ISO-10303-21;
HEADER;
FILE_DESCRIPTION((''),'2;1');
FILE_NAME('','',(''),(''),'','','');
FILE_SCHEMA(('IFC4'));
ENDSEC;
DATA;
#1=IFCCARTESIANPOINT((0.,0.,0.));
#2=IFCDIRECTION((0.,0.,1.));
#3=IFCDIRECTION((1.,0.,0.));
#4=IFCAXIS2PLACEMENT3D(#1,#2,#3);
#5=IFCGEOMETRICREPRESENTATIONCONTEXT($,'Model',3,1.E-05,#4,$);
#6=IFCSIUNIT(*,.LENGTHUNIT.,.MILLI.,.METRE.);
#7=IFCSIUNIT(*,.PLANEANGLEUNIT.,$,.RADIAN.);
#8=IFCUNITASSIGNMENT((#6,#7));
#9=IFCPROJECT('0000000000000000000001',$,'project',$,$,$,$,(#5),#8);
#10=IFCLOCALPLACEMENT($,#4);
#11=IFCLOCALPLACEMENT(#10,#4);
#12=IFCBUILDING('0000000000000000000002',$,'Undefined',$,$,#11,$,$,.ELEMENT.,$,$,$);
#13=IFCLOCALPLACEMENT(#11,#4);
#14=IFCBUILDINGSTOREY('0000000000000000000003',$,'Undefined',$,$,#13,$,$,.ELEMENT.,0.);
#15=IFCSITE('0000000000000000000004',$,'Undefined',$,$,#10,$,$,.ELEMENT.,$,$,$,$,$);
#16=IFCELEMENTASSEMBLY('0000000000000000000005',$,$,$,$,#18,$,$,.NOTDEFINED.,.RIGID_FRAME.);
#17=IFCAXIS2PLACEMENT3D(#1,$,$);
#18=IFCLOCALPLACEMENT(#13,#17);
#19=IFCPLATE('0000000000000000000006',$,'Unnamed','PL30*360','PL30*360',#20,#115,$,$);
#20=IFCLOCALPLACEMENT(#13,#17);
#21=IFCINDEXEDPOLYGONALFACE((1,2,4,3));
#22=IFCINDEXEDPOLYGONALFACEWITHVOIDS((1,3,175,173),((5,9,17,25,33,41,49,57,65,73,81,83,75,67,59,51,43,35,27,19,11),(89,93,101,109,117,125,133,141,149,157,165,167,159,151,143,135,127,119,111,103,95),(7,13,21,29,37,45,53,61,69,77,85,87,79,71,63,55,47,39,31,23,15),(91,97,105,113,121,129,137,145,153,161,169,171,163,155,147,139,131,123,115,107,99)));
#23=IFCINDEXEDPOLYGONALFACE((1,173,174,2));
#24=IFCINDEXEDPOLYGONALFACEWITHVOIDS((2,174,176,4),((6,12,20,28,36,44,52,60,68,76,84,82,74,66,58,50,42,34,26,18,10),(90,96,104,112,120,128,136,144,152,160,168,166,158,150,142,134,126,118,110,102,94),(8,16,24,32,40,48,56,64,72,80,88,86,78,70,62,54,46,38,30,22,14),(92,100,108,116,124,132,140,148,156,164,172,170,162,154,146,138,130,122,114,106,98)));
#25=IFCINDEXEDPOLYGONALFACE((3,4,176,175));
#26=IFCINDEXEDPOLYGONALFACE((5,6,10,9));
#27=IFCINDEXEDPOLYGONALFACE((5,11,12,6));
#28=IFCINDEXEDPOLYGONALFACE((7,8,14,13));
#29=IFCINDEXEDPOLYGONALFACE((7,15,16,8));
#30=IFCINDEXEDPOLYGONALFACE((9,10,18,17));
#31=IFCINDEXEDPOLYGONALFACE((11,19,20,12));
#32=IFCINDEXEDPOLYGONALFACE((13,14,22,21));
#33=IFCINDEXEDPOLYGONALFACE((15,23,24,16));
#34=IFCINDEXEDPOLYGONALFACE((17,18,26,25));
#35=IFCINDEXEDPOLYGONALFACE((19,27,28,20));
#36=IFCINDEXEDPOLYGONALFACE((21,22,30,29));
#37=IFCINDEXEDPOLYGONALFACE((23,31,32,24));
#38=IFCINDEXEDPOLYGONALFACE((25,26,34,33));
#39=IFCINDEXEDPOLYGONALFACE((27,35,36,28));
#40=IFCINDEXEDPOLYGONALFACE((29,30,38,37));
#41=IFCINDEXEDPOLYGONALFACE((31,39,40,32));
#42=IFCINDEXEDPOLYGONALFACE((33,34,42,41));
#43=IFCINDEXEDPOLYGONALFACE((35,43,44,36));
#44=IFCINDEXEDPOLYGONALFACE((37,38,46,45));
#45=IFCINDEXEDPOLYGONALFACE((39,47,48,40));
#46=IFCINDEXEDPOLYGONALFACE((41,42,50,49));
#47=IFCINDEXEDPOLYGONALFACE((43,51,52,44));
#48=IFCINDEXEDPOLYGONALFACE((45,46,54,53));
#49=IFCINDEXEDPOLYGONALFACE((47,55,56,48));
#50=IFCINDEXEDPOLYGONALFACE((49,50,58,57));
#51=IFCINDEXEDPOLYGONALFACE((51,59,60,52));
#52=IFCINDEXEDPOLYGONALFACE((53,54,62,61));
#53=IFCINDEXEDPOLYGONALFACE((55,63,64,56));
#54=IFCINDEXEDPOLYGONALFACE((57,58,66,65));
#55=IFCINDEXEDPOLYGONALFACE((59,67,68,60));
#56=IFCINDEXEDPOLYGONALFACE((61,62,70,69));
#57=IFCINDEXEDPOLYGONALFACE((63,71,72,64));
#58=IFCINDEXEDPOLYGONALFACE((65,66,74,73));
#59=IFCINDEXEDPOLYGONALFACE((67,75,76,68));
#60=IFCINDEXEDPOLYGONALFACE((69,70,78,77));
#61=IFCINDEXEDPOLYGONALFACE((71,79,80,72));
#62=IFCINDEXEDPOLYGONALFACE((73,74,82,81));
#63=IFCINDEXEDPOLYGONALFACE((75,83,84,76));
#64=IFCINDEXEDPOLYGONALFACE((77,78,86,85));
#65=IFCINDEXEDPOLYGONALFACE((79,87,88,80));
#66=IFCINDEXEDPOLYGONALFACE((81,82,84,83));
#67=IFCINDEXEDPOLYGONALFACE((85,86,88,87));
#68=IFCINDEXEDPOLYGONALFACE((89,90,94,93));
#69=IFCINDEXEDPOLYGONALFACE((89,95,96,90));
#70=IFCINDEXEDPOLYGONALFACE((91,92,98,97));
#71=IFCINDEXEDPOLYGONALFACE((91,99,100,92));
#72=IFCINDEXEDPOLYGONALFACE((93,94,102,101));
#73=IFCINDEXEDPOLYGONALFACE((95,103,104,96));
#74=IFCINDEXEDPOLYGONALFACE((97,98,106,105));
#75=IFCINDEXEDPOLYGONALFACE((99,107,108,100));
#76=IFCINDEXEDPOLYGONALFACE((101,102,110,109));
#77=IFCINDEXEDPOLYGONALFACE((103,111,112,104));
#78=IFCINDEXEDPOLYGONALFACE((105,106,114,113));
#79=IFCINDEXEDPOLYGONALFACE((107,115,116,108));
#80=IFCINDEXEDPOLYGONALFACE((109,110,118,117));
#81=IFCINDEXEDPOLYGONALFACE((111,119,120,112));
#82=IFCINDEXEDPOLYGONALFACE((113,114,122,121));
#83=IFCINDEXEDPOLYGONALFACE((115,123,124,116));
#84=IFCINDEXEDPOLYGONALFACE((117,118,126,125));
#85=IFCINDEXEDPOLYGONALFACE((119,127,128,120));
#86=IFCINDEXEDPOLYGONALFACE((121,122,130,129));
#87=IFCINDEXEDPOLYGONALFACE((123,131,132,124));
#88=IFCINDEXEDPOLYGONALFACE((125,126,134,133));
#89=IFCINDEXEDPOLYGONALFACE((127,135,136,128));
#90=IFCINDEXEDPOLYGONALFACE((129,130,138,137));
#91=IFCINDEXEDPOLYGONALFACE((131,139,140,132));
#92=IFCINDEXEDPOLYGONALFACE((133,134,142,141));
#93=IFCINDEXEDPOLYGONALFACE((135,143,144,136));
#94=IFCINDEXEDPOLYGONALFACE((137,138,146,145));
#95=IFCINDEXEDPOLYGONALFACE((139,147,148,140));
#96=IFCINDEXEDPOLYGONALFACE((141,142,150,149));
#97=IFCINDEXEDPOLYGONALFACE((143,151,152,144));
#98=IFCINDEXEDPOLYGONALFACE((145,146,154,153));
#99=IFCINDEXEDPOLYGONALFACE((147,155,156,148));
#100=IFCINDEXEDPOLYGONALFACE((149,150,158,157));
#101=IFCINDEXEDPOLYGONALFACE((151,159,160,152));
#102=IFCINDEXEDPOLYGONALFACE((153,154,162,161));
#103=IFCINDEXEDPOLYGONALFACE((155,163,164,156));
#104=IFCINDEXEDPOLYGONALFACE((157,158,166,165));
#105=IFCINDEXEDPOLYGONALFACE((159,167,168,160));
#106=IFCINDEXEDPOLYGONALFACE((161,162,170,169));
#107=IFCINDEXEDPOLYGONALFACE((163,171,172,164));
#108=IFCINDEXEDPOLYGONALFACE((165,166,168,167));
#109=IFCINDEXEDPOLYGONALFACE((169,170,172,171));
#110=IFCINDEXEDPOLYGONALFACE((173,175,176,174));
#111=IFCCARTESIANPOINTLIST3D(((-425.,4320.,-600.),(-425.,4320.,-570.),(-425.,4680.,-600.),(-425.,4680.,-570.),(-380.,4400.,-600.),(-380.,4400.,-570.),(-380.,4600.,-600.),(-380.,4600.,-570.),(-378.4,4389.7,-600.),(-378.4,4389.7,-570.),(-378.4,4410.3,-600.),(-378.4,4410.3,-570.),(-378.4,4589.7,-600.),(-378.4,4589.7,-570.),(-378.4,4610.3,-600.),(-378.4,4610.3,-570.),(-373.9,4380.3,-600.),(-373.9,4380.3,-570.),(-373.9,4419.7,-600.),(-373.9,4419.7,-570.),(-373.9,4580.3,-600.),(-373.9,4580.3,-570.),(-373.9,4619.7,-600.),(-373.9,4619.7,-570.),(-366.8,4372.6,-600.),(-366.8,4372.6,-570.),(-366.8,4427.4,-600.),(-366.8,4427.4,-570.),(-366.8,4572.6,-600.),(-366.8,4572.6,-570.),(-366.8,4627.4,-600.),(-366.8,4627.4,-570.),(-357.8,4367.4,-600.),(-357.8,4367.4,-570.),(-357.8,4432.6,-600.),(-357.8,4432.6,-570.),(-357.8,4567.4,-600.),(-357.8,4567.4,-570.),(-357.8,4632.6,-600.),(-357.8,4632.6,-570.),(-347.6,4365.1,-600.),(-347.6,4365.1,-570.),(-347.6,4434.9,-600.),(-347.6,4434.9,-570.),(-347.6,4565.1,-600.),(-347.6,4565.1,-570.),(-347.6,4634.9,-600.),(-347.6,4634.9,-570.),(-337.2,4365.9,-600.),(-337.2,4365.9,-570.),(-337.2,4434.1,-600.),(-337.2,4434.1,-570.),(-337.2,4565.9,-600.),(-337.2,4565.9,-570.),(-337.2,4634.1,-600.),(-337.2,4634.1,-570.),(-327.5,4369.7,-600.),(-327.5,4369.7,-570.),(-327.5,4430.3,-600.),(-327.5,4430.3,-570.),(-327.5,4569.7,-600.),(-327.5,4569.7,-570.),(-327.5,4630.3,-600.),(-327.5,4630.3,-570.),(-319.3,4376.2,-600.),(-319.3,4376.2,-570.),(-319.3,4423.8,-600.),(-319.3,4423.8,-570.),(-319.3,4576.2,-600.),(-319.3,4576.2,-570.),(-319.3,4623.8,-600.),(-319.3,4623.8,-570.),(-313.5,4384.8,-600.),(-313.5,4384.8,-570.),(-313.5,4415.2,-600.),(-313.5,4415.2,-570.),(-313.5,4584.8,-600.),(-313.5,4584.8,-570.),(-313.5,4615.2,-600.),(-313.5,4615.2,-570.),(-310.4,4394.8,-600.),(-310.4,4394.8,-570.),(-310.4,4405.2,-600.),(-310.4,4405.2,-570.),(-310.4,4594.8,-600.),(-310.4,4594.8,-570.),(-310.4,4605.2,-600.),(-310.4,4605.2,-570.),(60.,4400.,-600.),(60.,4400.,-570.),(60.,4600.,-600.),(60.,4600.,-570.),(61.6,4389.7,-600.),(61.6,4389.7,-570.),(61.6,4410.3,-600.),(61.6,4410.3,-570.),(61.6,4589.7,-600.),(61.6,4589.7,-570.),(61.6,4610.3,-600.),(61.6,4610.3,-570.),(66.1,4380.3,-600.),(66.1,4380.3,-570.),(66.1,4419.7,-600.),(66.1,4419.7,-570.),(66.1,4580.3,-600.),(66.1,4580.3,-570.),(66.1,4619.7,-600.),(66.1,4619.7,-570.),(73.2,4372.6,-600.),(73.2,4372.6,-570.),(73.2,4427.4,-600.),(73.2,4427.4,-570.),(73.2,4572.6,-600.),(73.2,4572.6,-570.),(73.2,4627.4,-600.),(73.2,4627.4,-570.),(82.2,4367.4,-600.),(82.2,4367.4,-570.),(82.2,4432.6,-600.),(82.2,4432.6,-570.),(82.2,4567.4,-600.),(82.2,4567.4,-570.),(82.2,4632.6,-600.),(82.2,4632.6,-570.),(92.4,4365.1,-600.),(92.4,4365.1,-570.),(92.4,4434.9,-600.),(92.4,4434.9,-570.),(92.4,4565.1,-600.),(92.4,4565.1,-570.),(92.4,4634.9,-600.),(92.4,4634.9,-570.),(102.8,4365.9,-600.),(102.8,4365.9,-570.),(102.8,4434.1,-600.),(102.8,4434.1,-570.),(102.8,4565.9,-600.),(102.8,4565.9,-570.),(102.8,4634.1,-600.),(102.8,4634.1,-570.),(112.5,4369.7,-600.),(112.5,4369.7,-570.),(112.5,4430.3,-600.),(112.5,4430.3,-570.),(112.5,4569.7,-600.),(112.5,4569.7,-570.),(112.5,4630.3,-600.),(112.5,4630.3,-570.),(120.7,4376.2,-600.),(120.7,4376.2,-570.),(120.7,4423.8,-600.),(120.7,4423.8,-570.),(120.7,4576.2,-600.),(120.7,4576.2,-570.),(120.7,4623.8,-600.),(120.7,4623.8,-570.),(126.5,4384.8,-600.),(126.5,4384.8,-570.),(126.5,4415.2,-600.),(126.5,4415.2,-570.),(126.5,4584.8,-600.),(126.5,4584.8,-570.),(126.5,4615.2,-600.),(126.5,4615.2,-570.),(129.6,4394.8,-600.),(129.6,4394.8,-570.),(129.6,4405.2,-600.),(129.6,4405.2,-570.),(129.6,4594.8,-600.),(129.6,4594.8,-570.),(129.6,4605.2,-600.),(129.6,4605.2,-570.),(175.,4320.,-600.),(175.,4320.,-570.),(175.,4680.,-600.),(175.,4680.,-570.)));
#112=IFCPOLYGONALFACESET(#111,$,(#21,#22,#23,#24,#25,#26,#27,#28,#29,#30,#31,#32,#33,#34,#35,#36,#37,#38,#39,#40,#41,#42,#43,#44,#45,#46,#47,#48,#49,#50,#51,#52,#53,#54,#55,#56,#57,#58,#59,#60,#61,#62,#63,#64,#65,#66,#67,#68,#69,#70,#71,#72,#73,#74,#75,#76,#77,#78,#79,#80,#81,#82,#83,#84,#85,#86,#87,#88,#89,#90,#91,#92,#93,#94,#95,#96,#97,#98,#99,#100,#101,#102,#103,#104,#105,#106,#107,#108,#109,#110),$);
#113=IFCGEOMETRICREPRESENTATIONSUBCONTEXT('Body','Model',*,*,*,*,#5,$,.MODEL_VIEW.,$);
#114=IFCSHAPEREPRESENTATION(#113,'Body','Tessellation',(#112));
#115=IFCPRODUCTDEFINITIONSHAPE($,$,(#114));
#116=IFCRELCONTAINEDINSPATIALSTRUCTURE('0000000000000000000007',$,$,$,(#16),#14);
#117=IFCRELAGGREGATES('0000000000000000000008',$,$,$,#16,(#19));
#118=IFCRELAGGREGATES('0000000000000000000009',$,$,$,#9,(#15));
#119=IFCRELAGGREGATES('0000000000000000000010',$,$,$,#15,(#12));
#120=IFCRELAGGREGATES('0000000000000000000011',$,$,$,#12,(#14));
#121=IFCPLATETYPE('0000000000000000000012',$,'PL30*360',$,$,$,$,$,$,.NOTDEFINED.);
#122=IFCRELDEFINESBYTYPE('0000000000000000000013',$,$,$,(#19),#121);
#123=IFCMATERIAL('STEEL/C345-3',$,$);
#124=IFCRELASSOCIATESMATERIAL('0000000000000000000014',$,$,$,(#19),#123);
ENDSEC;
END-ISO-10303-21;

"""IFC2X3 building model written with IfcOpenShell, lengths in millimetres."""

from ifc_helpers import new_model, si_unit, frame, origin_with_axes, origin_2d_with_axis, place, context, subcontext, project, spatial, polyline, circle, outline, extrude, boolean, material, type_object, element, aggregate, save


model = new_model("IFC2X3")

# Units and contexts
model_context = context("Model", 3, precision=1e-05, world=origin_with_axes())
body_context = subcontext(model_context, "Body", "Model", "MODEL_VIEW")
ifc_project = project(units=[si_unit("LENGTHUNIT", "METRE", prefix="MILLI"), si_unit("PLANEANGLEUNIT", "RADIAN")], contexts=[model_context])

# Site, building, storey
site_placement = place(None, origin_with_axes())
site = spatial("IfcSite", under=ifc_project, at=site_placement, Name="Undefined", CompositionType="ELEMENT")
building_placement = place(site_placement, origin_with_axes())
building = spatial("IfcBuilding", under=site, at=building_placement, Name="Undefined", CompositionType="ELEMENT")
storey_placement = place(building_placement, origin_with_axes())
storey = spatial("IfcBuildingStorey", under=building, at=storey_placement, Name="Undefined", CompositionType="ELEMENT", Elevation=0.0)

# Shared definitions
ifc_material_1 = material(Name="STEEL/C345-3")

# Element assembly, plate
assembly_1_placement = place(storey_placement, origin_with_axes())
assembly_1 = element("IfcElementAssembly", 1, at=assembly_1_placement, inside=storey, AssemblyPlace="NOTDEFINED", PredefinedType="RIGID_FRAME")
plate_type_1 = type_object("IfcPlateType", Name="PL30*360", PredefinedType="NOTDEFINED")
plate_1_placement = place(assembly_1_placement, frame((-425.0, 4680.0, -585.0), z_axis=(0.0, 0.0, 1.0), x_axis=(0.0, -1.0, 0.0)))
plate_1 = element("IfcPlate", 2, at=plate_1_placement, type_object=plate_type_1, material=ifc_material_1, Name="Unnamed", Description="PL30*360", ObjectType="PL30*360", context=body_context, shape_type="CSG", body=[
    boolean("DIFFERENCE", boolean("DIFFERENCE", boolean("DIFFERENCE", boolean("DIFFERENCE", extrude(outline(polyline([(0.0, 0.0), (360.0, 0.0), (360.0, 600.0), (0.0, 600.0), (0.0, 0.0)])), frame((0.0, 0.0, -15.0), z_axis=(0.0, 0.0, 1.0), x_axis=(1.0, 0.0, 0.0)), (0.0, 0.0, 1.0), 30.0), extrude(circle(Radius=35.0, at=origin_2d_with_axis()), frame((80.0, 520.0, 25.0), z_axis=(0.0, 0.0, -1.0), x_axis=(0.0, -1.0, 0.0)), (0.0, 0.0, 1.0), 60.0)), extrude(circle(Radius=35.0, at=origin_2d_with_axis()), frame((280.0, 520.0, 25.0), z_axis=(0.0, 0.0, -1.0), x_axis=(0.0, -1.0, 0.0)), (0.0, 0.0, 1.0), 60.0)), extrude(circle(Radius=35.0, at=origin_2d_with_axis()), frame((80.0, 80.0, 25.0), z_axis=(0.0, 0.0, -1.0), x_axis=(0.0, -1.0, 0.0)), (0.0, 0.0, 1.0), 60.0)), extrude(circle(Radius=35.0, at=origin_2d_with_axis()), frame((280.0, 80.0, 25.0), z_axis=(0.0, 0.0, -1.0), x_axis=(0.0, -1.0, 0.0)), (0.0, 0.0, 1.0), 60.0)),
])
aggregate(assembly_1, [plate_1])

save(model, "model.ifc")
